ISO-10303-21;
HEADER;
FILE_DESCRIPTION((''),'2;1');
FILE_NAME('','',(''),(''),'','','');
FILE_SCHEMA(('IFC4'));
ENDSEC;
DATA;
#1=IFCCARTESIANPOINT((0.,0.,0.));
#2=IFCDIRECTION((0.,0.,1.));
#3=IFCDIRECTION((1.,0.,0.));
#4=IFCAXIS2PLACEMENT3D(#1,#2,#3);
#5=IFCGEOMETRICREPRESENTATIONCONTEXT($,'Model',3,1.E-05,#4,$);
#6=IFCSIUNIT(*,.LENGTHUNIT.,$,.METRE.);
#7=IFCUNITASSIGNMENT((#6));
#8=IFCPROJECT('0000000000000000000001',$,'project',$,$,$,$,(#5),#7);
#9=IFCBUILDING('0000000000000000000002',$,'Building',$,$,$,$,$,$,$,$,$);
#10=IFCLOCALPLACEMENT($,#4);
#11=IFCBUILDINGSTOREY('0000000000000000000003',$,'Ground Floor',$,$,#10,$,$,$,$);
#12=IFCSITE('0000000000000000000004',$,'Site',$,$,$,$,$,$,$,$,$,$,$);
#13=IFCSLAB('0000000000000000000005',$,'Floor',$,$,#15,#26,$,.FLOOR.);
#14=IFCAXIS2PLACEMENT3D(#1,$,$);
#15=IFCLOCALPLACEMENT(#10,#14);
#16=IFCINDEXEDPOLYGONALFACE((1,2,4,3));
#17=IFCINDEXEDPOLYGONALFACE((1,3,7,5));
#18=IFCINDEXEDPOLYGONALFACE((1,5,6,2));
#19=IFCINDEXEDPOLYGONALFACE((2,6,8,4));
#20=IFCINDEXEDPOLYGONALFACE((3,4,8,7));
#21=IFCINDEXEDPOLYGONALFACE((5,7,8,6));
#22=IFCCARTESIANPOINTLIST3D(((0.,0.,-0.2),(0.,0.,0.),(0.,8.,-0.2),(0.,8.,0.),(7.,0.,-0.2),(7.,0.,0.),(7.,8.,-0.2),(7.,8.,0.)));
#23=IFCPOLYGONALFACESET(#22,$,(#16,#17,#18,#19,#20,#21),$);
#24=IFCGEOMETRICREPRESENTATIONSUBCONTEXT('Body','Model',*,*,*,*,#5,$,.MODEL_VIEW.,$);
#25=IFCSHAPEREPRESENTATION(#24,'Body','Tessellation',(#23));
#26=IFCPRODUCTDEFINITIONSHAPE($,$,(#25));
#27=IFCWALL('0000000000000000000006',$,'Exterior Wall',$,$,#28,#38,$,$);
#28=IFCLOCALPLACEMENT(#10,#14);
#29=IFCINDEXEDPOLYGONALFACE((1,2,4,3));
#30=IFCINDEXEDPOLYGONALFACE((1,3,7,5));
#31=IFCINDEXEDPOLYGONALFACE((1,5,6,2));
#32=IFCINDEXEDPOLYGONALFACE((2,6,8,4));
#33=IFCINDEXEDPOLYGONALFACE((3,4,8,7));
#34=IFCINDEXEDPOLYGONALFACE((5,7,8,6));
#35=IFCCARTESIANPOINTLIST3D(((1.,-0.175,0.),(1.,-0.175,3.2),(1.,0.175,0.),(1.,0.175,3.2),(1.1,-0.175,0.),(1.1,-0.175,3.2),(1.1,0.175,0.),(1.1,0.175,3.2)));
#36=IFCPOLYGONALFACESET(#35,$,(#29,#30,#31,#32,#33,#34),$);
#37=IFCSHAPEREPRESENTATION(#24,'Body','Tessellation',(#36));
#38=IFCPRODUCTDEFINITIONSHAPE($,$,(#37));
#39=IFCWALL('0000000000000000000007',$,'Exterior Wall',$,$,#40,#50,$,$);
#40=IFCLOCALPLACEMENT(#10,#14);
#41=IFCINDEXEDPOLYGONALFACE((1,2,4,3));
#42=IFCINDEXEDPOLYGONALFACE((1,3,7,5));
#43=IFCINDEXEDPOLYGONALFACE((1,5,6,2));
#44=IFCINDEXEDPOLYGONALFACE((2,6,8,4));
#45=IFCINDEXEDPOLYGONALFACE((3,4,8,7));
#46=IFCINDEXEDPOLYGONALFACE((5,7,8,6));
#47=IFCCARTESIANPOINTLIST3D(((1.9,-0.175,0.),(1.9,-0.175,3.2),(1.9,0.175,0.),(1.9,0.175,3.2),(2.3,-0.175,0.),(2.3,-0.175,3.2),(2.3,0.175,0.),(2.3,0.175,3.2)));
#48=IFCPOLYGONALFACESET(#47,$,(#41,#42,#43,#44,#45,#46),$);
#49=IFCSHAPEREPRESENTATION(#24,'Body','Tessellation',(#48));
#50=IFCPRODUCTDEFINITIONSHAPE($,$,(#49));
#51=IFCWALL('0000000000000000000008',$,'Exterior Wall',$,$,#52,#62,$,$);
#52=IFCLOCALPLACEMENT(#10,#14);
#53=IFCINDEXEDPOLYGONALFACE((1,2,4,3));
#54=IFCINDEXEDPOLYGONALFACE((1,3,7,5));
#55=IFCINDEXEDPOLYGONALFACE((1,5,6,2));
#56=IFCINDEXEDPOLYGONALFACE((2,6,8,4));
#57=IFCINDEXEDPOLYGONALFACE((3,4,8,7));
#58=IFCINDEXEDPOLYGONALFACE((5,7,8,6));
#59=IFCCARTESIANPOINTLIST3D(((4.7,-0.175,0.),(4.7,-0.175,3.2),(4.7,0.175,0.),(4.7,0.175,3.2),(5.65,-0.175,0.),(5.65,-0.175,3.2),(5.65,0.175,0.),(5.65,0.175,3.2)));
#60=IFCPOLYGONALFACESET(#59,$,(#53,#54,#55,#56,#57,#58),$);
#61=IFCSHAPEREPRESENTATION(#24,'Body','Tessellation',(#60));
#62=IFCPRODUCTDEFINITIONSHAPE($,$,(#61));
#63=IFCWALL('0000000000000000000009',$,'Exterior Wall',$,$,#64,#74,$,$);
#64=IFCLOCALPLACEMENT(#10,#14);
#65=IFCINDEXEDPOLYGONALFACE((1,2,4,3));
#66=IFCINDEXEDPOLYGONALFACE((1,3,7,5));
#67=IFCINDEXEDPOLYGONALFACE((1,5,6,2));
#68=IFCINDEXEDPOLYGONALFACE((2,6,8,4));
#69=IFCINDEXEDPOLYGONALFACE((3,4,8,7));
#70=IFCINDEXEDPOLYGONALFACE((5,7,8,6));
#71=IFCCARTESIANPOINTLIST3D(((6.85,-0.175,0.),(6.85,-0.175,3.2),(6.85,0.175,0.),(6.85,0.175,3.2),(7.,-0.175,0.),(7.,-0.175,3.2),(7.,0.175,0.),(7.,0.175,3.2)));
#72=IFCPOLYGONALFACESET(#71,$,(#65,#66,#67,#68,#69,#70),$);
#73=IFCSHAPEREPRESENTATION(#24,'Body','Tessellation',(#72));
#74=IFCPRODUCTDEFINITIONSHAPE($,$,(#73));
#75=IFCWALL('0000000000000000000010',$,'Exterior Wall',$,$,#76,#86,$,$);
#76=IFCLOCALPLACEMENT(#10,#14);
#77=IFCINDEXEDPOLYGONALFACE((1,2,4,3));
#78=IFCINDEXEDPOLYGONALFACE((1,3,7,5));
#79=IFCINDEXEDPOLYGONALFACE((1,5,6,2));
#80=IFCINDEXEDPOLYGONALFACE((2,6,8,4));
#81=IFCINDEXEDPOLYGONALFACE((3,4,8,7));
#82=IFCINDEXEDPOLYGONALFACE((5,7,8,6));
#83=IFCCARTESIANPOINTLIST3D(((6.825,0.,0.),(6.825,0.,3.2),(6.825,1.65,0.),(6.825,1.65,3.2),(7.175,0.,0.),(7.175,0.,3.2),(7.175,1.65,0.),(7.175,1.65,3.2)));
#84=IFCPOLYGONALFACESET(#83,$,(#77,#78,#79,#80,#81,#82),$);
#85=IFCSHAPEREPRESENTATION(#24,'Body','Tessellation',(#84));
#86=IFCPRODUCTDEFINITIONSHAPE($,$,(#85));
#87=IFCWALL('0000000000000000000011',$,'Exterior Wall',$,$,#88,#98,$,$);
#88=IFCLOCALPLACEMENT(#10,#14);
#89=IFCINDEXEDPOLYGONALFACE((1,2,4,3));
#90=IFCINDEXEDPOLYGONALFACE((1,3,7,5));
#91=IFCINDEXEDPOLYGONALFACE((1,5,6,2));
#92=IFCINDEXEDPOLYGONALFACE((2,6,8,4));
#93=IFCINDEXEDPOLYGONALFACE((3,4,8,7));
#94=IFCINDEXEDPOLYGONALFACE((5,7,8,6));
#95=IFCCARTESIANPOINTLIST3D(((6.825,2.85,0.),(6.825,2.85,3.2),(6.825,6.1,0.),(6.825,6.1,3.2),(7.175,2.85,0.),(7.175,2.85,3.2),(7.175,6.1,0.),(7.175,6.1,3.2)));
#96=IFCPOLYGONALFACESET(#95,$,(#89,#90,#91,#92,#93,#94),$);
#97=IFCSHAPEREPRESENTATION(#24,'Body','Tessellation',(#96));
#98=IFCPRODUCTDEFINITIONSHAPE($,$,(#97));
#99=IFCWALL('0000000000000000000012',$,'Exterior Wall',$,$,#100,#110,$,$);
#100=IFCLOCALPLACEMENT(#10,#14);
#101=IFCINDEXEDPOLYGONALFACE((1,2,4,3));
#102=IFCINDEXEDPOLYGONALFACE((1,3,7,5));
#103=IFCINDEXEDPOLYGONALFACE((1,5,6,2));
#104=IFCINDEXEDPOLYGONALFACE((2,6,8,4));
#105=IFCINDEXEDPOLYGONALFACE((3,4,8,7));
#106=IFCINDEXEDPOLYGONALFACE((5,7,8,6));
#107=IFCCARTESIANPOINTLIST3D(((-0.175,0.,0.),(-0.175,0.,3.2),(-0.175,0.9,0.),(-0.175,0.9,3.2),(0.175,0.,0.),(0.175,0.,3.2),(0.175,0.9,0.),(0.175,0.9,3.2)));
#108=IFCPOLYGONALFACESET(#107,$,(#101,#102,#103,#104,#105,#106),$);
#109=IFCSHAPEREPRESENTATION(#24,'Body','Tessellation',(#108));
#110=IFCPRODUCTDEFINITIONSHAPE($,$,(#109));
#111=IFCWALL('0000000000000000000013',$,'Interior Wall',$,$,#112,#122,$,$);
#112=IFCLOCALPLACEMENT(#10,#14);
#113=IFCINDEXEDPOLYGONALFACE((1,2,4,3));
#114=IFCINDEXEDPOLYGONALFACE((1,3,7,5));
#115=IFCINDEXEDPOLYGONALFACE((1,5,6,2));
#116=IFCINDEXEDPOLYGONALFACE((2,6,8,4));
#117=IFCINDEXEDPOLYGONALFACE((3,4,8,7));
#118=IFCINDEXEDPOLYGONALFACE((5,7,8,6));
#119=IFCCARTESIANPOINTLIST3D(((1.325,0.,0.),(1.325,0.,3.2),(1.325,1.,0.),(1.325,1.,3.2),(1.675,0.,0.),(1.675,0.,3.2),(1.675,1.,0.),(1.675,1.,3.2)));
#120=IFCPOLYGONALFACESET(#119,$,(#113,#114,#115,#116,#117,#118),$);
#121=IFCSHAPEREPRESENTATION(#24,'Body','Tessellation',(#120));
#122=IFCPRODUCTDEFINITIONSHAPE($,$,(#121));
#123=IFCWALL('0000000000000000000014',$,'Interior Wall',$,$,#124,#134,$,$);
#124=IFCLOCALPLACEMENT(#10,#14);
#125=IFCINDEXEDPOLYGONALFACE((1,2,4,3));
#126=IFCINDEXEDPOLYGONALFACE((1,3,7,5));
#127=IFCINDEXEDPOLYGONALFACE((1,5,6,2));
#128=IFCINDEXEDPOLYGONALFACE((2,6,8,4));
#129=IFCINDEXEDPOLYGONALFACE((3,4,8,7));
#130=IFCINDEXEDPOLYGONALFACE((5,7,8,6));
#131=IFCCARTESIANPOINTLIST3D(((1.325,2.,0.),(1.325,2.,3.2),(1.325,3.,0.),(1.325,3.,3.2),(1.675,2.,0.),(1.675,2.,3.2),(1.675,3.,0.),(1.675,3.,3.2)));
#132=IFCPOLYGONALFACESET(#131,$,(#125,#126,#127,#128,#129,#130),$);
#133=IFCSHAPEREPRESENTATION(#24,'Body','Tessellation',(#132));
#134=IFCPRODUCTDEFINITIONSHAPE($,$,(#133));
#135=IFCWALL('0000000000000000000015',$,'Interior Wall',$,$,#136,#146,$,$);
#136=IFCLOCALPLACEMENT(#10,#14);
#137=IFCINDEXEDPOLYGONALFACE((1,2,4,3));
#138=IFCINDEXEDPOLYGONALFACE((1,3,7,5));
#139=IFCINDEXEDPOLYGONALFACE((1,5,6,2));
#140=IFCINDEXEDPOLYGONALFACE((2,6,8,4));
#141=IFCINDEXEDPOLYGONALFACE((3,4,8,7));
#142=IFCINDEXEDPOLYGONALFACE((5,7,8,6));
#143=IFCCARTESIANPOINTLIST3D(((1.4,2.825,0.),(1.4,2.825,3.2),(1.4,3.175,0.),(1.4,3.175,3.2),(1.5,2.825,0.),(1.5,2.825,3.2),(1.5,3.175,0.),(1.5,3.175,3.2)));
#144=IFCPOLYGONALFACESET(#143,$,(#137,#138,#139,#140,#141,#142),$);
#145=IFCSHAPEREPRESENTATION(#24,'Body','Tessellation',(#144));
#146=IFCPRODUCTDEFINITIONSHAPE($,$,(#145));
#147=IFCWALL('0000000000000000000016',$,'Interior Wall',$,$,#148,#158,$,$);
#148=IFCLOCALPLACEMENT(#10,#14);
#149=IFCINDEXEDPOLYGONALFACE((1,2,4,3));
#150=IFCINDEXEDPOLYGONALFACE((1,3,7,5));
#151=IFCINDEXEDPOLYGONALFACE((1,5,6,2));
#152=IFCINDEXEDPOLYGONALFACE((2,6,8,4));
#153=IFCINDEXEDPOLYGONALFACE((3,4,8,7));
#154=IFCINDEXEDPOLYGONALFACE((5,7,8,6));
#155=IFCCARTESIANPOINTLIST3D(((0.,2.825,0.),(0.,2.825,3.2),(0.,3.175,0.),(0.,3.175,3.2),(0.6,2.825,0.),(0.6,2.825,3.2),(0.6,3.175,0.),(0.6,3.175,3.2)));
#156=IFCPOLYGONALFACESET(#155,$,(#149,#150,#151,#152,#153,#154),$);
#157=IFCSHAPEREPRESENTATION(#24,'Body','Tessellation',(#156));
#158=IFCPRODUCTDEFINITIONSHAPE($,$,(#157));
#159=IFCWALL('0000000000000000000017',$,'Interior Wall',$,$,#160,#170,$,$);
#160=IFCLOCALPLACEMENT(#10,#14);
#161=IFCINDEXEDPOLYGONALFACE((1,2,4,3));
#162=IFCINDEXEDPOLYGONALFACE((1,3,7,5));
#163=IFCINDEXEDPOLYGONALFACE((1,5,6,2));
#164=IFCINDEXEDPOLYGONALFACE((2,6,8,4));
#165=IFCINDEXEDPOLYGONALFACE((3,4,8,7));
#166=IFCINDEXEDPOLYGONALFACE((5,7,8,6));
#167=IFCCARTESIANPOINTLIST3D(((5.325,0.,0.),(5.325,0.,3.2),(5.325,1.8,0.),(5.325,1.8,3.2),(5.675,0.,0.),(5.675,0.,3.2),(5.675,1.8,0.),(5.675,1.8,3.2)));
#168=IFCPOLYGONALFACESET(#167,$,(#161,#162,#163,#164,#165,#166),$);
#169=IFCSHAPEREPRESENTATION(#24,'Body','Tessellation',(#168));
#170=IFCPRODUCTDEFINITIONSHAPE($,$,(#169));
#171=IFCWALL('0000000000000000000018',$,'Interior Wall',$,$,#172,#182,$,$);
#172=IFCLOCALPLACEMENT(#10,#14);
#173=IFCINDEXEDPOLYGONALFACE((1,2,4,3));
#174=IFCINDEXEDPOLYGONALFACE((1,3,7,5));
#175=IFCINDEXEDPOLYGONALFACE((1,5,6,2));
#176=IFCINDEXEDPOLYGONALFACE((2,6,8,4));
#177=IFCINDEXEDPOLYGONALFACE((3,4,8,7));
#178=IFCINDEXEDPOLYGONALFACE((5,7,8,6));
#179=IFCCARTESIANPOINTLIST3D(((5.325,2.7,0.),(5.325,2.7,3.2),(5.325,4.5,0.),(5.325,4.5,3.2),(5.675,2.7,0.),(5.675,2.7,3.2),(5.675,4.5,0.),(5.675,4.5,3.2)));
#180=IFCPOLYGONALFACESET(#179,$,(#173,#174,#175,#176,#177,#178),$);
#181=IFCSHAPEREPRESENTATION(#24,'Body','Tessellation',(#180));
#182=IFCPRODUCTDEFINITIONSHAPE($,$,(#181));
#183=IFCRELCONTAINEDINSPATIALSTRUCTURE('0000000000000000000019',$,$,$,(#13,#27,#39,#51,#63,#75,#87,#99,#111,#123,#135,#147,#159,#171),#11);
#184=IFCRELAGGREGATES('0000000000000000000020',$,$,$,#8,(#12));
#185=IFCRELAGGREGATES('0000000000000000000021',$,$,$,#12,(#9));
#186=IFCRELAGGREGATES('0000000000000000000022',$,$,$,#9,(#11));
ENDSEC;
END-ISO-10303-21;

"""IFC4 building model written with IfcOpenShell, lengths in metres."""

from ifc_helpers import new_model, si_unit, frame, origin_with_axes, place, context, subcontext, project, spatial, indexed_curve, outline, extrude, element, save


model = new_model("IFC4")

# Units and contexts
model_context = context("Model", 3, precision=1e-05, world=origin_with_axes())
body_context = subcontext(model_context, "Body", "Model", "MODEL_VIEW")
ifc_project = project(units=[si_unit("LENGTHUNIT", "METRE")], contexts=[model_context])

# Site, building, storey
site = spatial("IfcSite", under=ifc_project, Name="Site")
building = spatial("IfcBuilding", under=site, Name="Building")
storey_placement = place(None, origin_with_axes())
storey = spatial("IfcBuildingStorey", under=building, at=storey_placement, Name="Ground Floor")

# Slab
slab_placement = place(storey_placement, frame((0.0, 0.0, -0.2), z_axis=(0.0, 0.0, 1.0), x_axis=(1.0, 0.0, 0.0)))
element("IfcSlab", 1, at=slab_placement, inside=storey, Name="Floor", PredefinedType="FLOOR", context=body_context, shape_type="SweptSolid", body=[
    extrude(outline(indexed_curve([(0.0, 0.0), (7.0, 0.0), (7.0, 8.0), (0.0, 8.0)])), None, (0.0, 0.0, 1.0), 0.2),
])

# Walls
wall_1_placement = place(storey_placement, frame((1.0, 0.0, 0.0), z_axis=(0.0, 0.0, 1.0), x_axis=(1.0, 0.0, 0.0)))
element("IfcWall", 2, at=wall_1_placement, inside=storey, Name="Exterior Wall", context=body_context, shape_type="SweptSolid", body=[
    extrude(outline(indexed_curve([(0.0, 0.0), (0.0, 0.35), (0.1, 0.35), (0.1, 0.0), (0.0, 0.0)], self_intersect=False)), frame((0.0, -0.175, 0.0), z_axis=(0.0, 0.0, 1.0), x_axis=(1.0, 0.0, 0.0)), (0.0, 0.0, 1.0), 3.2),
])
wall_2_placement = place(storey_placement, frame((1.9, 0.0, 0.0), z_axis=(0.0, 0.0, 1.0), x_axis=(1.0, 0.0, 0.0)))
element("IfcWall", 3, at=wall_2_placement, inside=storey, Name="Exterior Wall", context=body_context, shape_type="SweptSolid", body=[
    extrude(outline(indexed_curve([(0.0, 0.0), (0.0, 0.35), (0.4, 0.35), (0.4, 0.0), (0.0, 0.0)], self_intersect=False)), frame((0.0, -0.175, 0.0), z_axis=(0.0, 0.0, 1.0), x_axis=(1.0, 0.0, 0.0)), (0.0, 0.0, 1.0), 3.2),
])
wall_3_placement = place(storey_placement, frame((4.7, 0.0, 0.0), z_axis=(0.0, 0.0, 1.0), x_axis=(1.0, 0.0, 0.0)))
element("IfcWall", 4, at=wall_3_placement, inside=storey, Name="Exterior Wall", context=body_context, shape_type="SweptSolid", body=[
    extrude(outline(indexed_curve([(0.0, 0.0), (0.0, 0.35), (0.95, 0.35), (0.95, 0.0), (0.0, 0.0)], self_intersect=False)), frame((0.0, -0.175, 0.0), z_axis=(0.0, 0.0, 1.0), x_axis=(1.0, 0.0, 0.0)), (0.0, 0.0, 1.0), 3.2),
])
wall_4_placement = place(storey_placement, frame((6.85, 0.0, 0.0), z_axis=(0.0, 0.0, 1.0), x_axis=(1.0, 0.0, 0.0)))
element("IfcWall", 5, at=wall_4_placement, inside=storey, Name="Exterior Wall", context=body_context, shape_type="SweptSolid", body=[
    extrude(outline(indexed_curve([(0.0, 0.0), (0.0, 0.35), (0.15, 0.35), (0.15, 0.0), (0.0, 0.0)], self_intersect=False)), frame((0.0, -0.175, 0.0), z_axis=(0.0, 0.0, 1.0), x_axis=(1.0, 0.0, 0.0)), (0.0, 0.0, 1.0), 3.2),
])
wall_5_placement = place(storey_placement, frame((7.0, 0.0, 0.0), z_axis=(0.0, 0.0, 1.0), x_axis=(0.0, 1.0, 0.0)))
element("IfcWall", 6, at=wall_5_placement, inside=storey, Name="Exterior Wall", context=body_context, shape_type="SweptSolid", body=[
    extrude(outline(indexed_curve([(0.0, 0.0), (0.0, 0.35), (1.65, 0.35), (1.65, 0.0), (0.0, 0.0)], self_intersect=False)), frame((0.0, -0.175, 0.0), z_axis=(0.0, 0.0, 1.0), x_axis=(1.0, 0.0, 0.0)), (0.0, 0.0, 1.0), 3.2),
])
wall_6_placement = place(storey_placement, frame((7.0, 2.85, 0.0), z_axis=(0.0, 0.0, 1.0), x_axis=(0.0, 1.0, 0.0)))
element("IfcWall", 7, at=wall_6_placement, inside=storey, Name="Exterior Wall", context=body_context, shape_type="SweptSolid", body=[
    extrude(outline(indexed_curve([(0.0, 0.0), (0.0, 0.35), (3.25, 0.35), (3.25, 0.0), (0.0, 0.0)], self_intersect=False)), frame((0.0, -0.175, 0.0), z_axis=(0.0, 0.0, 1.0), x_axis=(1.0, 0.0, 0.0)), (0.0, 0.0, 1.0), 3.2),
])
wall_7_placement = place(storey_placement, frame((0.0, 0.9, 0.0), z_axis=(0.0, 0.0, 1.0), x_axis=(0.0, -1.0, 0.0)))
element("IfcWall", 8, at=wall_7_placement, inside=storey, Name="Exterior Wall", context=body_context, shape_type="SweptSolid", body=[
    extrude(outline(indexed_curve([(0.0, 0.0), (0.0, 0.35), (0.9, 0.35), (0.9, 0.0), (0.0, 0.0)], self_intersect=False)), frame((0.0, -0.175, 0.0), z_axis=(0.0, 0.0, 1.0), x_axis=(1.0, 0.0, 0.0)), (0.0, 0.0, 1.0), 3.2),
])
for number, where, z_axis, x_axis, name in (
    (9, (1.5, 0.0, 0.0), (0.0, 0.0, 1.0), (0.0, 1.0, 0.0), "Interior Wall"),
    (10, (1.5, 2.0, 0.0), (0.0, 0.0, 1.0), (0.0, 1.0, 0.0), "Interior Wall"),
):
    element("IfcWall", number, at=place(storey_placement, frame(where, z_axis=z_axis, x_axis=x_axis)), inside=storey, Name=name, context=body_context, shape_type="SweptSolid", body=[
        extrude(outline(indexed_curve([(0.0, 0.0), (0.0, 0.35), (1.0, 0.35), (1.0, 0.0), (0.0, 0.0)], self_intersect=False)), frame((0.0, -0.175, 0.0), z_axis=(0.0, 0.0, 1.0), x_axis=(1.0, 0.0, 0.0)), (0.0, 0.0, 1.0), 3.2),
    ])
wall_8_placement = place(storey_placement, frame((1.5, 3.0, 0.0), z_axis=(0.0, 0.0, 1.0), x_axis=(-1.0, 0.0, 0.0)))
element("IfcWall", 11, at=wall_8_placement, inside=storey, Name="Interior Wall", context=body_context, shape_type="SweptSolid", body=[
    extrude(outline(indexed_curve([(0.0, 0.0), (0.0, 0.35), (0.1, 0.35), (0.1, 0.0), (0.0, 0.0)], self_intersect=False)), frame((0.0, -0.175, 0.0), z_axis=(0.0, 0.0, 1.0), x_axis=(1.0, 0.0, 0.0)), (0.0, 0.0, 1.0), 3.2),
])
wall_9_placement = place(storey_placement, frame((0.6, 3.0, 0.0), z_axis=(0.0, 0.0, 1.0), x_axis=(-1.0, 0.0, 0.0)))
element("IfcWall", 12, at=wall_9_placement, inside=storey, Name="Interior Wall", context=body_context, shape_type="SweptSolid", body=[
    extrude(outline(indexed_curve([(0.0, 0.0), (0.0, 0.35), (0.6, 0.35), (0.6, 0.0), (0.0, 0.0)], self_intersect=False)), frame((0.0, -0.175, 0.0), z_axis=(0.0, 0.0, 1.0), x_axis=(1.0, 0.0, 0.0)), (0.0, 0.0, 1.0), 3.2),
])
wall_10_placement = place(storey_placement, frame((5.5, 0.0, 0.0), z_axis=(0.0, 0.0, 1.0), x_axis=(0.0, 1.0, 0.0)))
element("IfcWall", 13, at=wall_10_placement, inside=storey, Name="Interior Wall", context=body_context, shape_type="SweptSolid", body=[
    extrude(outline(indexed_curve([(0.0, 0.0), (0.0, 0.35), (1.8, 0.35), (1.8, 0.0), (0.0, 0.0)], self_intersect=False)), frame((0.0, -0.175, 0.0), z_axis=(0.0, 0.0, 1.0), x_axis=(1.0, 0.0, 0.0)), (0.0, 0.0, 1.0), 3.2),
])
wall_11_placement = place(storey_placement, frame((5.5, 2.7, 0.0), z_axis=(0.0, 0.0, 1.0), x_axis=(0.0, 1.0, 0.0)))
element("IfcWall", 14, at=wall_11_placement, inside=storey, Name="Interior Wall", context=body_context, shape_type="SweptSolid", body=[
    extrude(outline(indexed_curve([(0.0, 0.0), (0.0, 0.35), (1.8, 0.35), (1.8, 0.0), (0.0, 0.0)], self_intersect=False)), frame((0.0, -0.175, 0.0), z_axis=(0.0, 0.0, 1.0), x_axis=(1.0, 0.0, 0.0)), (0.0, 0.0, 1.0), 3.2),
])

save(model, "model.ifc")
